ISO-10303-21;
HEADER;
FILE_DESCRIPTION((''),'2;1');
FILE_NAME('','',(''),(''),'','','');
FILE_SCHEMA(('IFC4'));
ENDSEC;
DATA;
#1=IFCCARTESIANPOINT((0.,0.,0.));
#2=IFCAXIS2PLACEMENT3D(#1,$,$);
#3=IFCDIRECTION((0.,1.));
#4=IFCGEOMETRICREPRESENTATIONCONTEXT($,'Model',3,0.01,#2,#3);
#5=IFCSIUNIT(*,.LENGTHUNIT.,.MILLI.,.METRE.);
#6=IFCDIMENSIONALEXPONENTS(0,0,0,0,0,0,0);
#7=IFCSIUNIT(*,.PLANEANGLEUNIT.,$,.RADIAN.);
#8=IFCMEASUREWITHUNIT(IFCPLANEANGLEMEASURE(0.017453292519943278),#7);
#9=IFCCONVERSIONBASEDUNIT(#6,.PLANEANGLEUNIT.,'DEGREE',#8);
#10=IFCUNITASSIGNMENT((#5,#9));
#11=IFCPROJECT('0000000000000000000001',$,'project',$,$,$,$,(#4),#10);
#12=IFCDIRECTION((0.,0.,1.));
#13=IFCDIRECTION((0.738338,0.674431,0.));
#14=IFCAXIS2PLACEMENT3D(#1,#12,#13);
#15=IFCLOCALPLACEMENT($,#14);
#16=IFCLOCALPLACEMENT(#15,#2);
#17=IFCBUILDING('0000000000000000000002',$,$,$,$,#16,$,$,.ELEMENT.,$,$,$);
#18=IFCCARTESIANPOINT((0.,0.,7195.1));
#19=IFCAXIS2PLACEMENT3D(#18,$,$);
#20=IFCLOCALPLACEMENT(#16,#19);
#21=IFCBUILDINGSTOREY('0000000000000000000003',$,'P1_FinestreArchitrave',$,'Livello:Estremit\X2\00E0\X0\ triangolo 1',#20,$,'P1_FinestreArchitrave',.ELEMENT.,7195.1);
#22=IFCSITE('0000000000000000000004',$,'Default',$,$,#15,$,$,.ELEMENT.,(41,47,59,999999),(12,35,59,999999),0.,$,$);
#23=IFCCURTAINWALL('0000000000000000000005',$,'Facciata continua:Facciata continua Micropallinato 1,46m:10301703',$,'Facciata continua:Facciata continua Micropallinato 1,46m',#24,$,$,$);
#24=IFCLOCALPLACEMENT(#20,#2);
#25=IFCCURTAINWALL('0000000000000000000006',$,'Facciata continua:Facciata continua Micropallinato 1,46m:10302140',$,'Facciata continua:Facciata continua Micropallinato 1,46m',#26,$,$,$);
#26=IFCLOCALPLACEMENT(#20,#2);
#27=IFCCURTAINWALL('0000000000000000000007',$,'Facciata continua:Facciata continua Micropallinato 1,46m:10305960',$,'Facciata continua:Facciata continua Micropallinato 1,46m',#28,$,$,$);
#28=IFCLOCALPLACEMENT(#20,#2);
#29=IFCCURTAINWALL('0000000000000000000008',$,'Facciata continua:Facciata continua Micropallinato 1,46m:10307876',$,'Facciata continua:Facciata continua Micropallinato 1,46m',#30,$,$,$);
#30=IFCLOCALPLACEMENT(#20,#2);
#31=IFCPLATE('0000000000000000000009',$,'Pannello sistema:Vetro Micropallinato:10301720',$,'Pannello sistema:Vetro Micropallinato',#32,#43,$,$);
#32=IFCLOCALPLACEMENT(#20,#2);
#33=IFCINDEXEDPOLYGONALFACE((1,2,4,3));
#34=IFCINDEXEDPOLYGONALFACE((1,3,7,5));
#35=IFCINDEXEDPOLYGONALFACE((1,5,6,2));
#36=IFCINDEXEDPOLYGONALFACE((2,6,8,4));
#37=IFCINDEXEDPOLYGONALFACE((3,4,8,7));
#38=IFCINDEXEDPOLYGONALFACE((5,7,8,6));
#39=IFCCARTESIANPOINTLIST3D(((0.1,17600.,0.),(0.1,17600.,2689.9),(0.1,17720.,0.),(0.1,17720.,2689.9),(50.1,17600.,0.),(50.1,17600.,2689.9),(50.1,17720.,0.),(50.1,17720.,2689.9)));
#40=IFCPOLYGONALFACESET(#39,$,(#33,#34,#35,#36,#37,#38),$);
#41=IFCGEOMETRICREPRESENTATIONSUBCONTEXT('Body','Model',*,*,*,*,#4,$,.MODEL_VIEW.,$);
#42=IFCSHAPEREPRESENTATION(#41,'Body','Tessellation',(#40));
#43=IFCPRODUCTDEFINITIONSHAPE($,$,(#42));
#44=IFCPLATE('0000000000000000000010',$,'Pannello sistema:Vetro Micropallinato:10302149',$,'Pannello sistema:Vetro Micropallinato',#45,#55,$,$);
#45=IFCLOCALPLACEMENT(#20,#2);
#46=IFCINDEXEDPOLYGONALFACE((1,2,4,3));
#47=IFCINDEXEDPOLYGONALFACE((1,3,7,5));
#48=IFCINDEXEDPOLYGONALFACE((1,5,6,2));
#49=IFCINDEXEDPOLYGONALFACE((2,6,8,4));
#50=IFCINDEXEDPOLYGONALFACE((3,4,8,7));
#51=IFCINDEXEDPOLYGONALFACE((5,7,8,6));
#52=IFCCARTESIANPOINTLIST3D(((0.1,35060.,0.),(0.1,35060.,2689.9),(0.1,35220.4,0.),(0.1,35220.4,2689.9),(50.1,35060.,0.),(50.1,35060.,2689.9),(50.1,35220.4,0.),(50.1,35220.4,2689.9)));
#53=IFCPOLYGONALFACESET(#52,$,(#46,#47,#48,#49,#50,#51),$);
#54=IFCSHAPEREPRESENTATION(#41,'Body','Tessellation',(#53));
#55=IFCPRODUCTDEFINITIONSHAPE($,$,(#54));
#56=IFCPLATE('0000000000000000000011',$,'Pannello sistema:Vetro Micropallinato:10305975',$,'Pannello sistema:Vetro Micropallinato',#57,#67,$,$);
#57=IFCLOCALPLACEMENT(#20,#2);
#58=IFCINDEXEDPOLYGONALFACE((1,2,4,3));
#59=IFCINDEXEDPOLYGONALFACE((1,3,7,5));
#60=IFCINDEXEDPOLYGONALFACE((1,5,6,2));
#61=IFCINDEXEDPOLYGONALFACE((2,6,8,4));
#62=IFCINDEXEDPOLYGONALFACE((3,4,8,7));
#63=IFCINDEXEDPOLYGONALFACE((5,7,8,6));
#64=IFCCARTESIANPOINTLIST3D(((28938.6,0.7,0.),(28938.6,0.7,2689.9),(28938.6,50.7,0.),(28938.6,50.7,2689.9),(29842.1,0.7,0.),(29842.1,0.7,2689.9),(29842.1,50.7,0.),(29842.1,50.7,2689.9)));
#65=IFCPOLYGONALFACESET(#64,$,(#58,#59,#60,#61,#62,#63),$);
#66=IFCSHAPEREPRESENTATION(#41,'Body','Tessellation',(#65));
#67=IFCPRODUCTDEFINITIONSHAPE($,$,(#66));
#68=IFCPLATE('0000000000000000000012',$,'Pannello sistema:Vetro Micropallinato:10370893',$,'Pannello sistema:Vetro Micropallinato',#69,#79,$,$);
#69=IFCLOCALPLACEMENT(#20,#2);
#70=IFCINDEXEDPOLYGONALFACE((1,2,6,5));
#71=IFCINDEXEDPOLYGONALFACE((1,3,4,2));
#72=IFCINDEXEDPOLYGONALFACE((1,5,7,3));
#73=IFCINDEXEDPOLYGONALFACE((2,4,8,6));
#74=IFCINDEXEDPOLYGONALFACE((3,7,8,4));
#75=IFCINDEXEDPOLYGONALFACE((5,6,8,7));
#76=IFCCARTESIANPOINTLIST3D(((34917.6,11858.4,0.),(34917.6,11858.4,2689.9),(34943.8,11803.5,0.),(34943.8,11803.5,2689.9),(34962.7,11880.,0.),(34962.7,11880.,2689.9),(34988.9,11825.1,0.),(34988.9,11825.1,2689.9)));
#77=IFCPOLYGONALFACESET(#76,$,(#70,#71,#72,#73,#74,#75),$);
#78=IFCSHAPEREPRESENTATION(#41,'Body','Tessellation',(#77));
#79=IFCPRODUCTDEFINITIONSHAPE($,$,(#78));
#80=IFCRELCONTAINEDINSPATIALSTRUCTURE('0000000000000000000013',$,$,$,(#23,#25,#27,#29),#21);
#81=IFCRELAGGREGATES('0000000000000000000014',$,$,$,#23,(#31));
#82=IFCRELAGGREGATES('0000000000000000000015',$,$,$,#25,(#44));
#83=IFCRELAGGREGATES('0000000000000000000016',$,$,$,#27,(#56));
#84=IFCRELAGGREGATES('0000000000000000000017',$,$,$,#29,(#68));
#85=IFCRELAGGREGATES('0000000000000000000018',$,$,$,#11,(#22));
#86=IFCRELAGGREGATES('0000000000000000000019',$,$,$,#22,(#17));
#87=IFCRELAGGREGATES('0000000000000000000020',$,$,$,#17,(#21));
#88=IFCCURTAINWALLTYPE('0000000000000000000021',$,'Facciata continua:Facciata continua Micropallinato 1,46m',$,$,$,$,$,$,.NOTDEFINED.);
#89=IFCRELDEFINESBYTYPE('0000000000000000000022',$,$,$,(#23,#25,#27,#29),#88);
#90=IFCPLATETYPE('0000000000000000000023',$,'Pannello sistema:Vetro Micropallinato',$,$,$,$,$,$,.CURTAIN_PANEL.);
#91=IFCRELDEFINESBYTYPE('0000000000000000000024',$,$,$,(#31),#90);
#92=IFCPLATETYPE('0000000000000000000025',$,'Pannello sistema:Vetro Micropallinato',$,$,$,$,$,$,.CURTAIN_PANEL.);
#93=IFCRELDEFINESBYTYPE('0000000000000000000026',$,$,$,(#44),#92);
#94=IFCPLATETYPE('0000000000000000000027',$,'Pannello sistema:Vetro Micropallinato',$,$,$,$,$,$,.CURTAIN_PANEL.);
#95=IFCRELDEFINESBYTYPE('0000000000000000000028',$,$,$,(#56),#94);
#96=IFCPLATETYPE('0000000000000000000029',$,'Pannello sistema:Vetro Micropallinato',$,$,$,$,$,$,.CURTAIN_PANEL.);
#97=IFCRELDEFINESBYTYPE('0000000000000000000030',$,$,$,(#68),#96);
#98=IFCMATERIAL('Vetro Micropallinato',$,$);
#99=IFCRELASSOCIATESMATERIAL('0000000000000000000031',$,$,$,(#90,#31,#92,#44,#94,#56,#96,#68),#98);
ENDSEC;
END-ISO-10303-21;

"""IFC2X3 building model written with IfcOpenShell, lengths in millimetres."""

from ifc_helpers import new_model, entity, si_unit, converted_unit, direction, frame, frame_2d, origin, origin_2d_with_axis, place, context, subcontext, project, spatial, rectangle, extrude, source, transform, mapped, material, type_object, type_shapes, element, aggregate, save


model = new_model("IFC2X3")

# Units and contexts
model_context = context("Model", 3, precision=0.01, world=origin(), true_north=direction((0.0, 1.0)))
body_context = subcontext(model_context, "Body", "Model", "MODEL_VIEW")
ifc_project = project(units=[si_unit("LENGTHUNIT", "METRE", prefix="MILLI"), converted_unit("PLANEANGLEUNIT", "DEGREE", entity("IfcPlaneAngleMeasure", 0.017453292519943278), si_unit("PLANEANGLEUNIT", "RADIAN"), dimensions=[0, 0, 0, 0, 0, 0, 0])], contexts=[model_context])

# Site, building, storey
site_placement = place(None, frame((0.0, 0.0, 0.0), z_axis=(0.0, 0.0, 1.0), x_axis=(0.738338, 0.674431, 0.0)))
site = spatial("IfcSite", under=ifc_project, at=site_placement, Name="Default", CompositionType="ELEMENT", RefLatitude=(41, 47, 59, 999999), RefLongitude=(12, 35, 59, 999999), RefElevation=0.0)
building_placement = place(site_placement, origin())
building = spatial("IfcBuilding", under=site, at=building_placement, CompositionType="ELEMENT")
storey_placement = place(building_placement, frame((0.0, 0.0, 7195.1)))
storey = spatial("IfcBuildingStorey", under=building, at=storey_placement, Name="P1_FinestreArchitrave", ObjectType="Livello:Estremità triangolo 1", LongName="P1_FinestreArchitrave", CompositionType="ELEMENT", Elevation=7195.1)

# Curtain walls
curtain_wall_type = type_object("IfcCurtainWallType", Name="Facciata continua:Facciata continua Micropallinato 1,46m", PredefinedType="NOTDEFINED")
curtain_wall_1_placement = place(storey_placement, frame((0.0, 0.0, -7195.1)))
curtain_wall_1 = element("IfcCurtainWall", 1, at=curtain_wall_1_placement, inside=storey, type_object=curtain_wall_type, Name="Facciata continua:Facciata continua Micropallinato 1,46m:10301703", ObjectType="Facciata continua:Facciata continua Micropallinato 1,46m")
ifc_material = material(Name="Vetro Micropallinato")
curtain_wall_2_placement = place(storey_placement, frame((0.0, 0.0, -7195.1)))
curtain_wall_2 = element("IfcCurtainWall", 2, at=curtain_wall_2_placement, inside=storey, type_object=curtain_wall_type, Name="Facciata continua:Facciata continua Micropallinato 1,46m:10302140", ObjectType="Facciata continua:Facciata continua Micropallinato 1,46m")
curtain_wall_3_placement = place(storey_placement, frame((0.0, 0.0, -7195.1)))
curtain_wall_3 = element("IfcCurtainWall", 3, at=curtain_wall_3_placement, inside=storey, type_object=curtain_wall_type, Name="Facciata continua:Facciata continua Micropallinato 1,46m:10305960", ObjectType="Facciata continua:Facciata continua Micropallinato 1,46m")
curtain_wall_4_placement = place(storey_placement, frame((0.0, 0.0, -7195.1)))
curtain_wall_4 = element("IfcCurtainWall", 4, at=curtain_wall_4_placement, inside=storey, type_object=curtain_wall_type, Name="Facciata continua:Facciata continua Micropallinato 1,46m:10307876", ObjectType="Facciata continua:Facciata continua Micropallinato 1,46m")

# Plates
plate_type_1 = type_object("IfcPlateType", Name="Pannello sistema:Vetro Micropallinato", PredefinedType="CURTAIN_PANEL", material=ifc_material)
shared_shape_1 = source(origin(), body_context, "Body", "SweptSolid", [
    extrude(rectangle(XDim=50.0, YDim=120.0, at=origin_2d_with_axis()), frame((0.0, -25.0, 0.0), z_axis=(0.0, 0.0, 1.0), x_axis=(0.0, 1.0, 0.0)), (0.0, 0.0, 1.0), 2689.9),
])
type_shapes(plate_type_1, [shared_shape_1])
plate_1_placement = place(curtain_wall_1_placement, frame((0.1, 17660.0, 7195.1), z_axis=(0.0, 0.0, 1.0), x_axis=(0.0, 1.0, 0.0)))
plate_1 = element("IfcPlate", 5, at=plate_1_placement, type_object=plate_type_1, material=ifc_material, Name="Pannello sistema:Vetro Micropallinato:10301720", ObjectType="Pannello sistema:Vetro Micropallinato", context=body_context, shape_type="MappedRepresentation", body=[
    mapped(shared_shape_1, transform((0.0, 0.0, 0.0), scale=1.0)),
])
aggregate(curtain_wall_1, [plate_1])
plate_type_2 = type_object("IfcPlateType", Name="Pannello sistema:Vetro Micropallinato", PredefinedType="CURTAIN_PANEL", material=ifc_material)
shared_shape_2 = source(origin(), body_context, "Body", "SweptSolid", [
    extrude(rectangle(XDim=50.0, YDim=160.4, at=origin_2d_with_axis()), frame((0.0, -25.0, 0.0), z_axis=(0.0, 0.0, 1.0), x_axis=(0.0, 1.0, 0.0)), (0.0, 0.0, 1.0), 2689.9),
])
type_shapes(plate_type_2, [shared_shape_2])
plate_2_placement = place(curtain_wall_2_placement, frame((0.1, 35140.2, 7195.1), z_axis=(0.0, 0.0, 1.0), x_axis=(0.0, 1.0, 0.0)))
plate_2 = element("IfcPlate", 6, at=plate_2_placement, type_object=plate_type_2, material=ifc_material, Name="Pannello sistema:Vetro Micropallinato:10302149", ObjectType="Pannello sistema:Vetro Micropallinato", context=body_context, shape_type="MappedRepresentation", body=[
    mapped(shared_shape_2, transform((0.0, 0.0, 0.0), scale=1.0)),
])
aggregate(curtain_wall_2, [plate_2])
plate_type_3 = type_object("IfcPlateType", Name="Pannello sistema:Vetro Micropallinato", PredefinedType="CURTAIN_PANEL", material=ifc_material)
shared_shape_3 = source(origin(), body_context, "Body", "SweptSolid", [
    extrude(rectangle(XDim=50.0, YDim=903.5, at=origin_2d_with_axis()), frame((0.0, -25.0, 0.0), z_axis=(0.0, 0.0, 1.0), x_axis=(0.0, 1.0, 0.0)), (0.0, 0.0, 1.0), 2689.9),
])
type_shapes(plate_type_3, [shared_shape_3])
plate_3_placement = place(curtain_wall_3_placement, frame((29390.4, 0.7, 7195.1), z_axis=(0.0, 0.0, 1.0), x_axis=(-1.0, 0.0, 0.0)))
plate_3 = element("IfcPlate", 7, at=plate_3_placement, type_object=plate_type_3, material=ifc_material, Name="Pannello sistema:Vetro Micropallinato:10305975", ObjectType="Pannello sistema:Vetro Micropallinato", context=body_context, shape_type="MappedRepresentation", body=[
    mapped(shared_shape_3, transform((0.0, 0.0, 0.0), scale=1.0)),
])
aggregate(curtain_wall_3, [plate_3])
plate_type_4 = type_object("IfcPlateType", Name="Pannello sistema:Vetro Micropallinato", PredefinedType="CURTAIN_PANEL", material=ifc_material)
shared_shape_4 = source(origin(), body_context, "Body", "SweptSolid", [
    extrude(rectangle(XDim=50.0, YDim=60.8, at=frame_2d((0.0, 0.0), x_axis=(1.0, 0.0))), frame((0.0, -25.0, 0.0), z_axis=(0.0, 0.0, 1.0), x_axis=(0.0, 1.0, 0.0)), (0.0, 0.0, 1.0), 2689.9),
])
type_shapes(plate_type_4, [shared_shape_4])
plate_4_placement = place(curtain_wall_4_placement, frame((34975.8, 11852.5, 7195.1), z_axis=(0.0, 0.0, 1.0), x_axis=(0.431105, -0.902302, 0.0)))
plate_4 = element("IfcPlate", 8, at=plate_4_placement, type_object=plate_type_4, material=ifc_material, Name="Pannello sistema:Vetro Micropallinato:10370893", ObjectType="Pannello sistema:Vetro Micropallinato", context=body_context, shape_type="MappedRepresentation", body=[
    mapped(shared_shape_4, transform((0.0, 0.0, 0.0), scale=1.0)),
])
aggregate(curtain_wall_4, [plate_4])

save(model, "model.ifc")
